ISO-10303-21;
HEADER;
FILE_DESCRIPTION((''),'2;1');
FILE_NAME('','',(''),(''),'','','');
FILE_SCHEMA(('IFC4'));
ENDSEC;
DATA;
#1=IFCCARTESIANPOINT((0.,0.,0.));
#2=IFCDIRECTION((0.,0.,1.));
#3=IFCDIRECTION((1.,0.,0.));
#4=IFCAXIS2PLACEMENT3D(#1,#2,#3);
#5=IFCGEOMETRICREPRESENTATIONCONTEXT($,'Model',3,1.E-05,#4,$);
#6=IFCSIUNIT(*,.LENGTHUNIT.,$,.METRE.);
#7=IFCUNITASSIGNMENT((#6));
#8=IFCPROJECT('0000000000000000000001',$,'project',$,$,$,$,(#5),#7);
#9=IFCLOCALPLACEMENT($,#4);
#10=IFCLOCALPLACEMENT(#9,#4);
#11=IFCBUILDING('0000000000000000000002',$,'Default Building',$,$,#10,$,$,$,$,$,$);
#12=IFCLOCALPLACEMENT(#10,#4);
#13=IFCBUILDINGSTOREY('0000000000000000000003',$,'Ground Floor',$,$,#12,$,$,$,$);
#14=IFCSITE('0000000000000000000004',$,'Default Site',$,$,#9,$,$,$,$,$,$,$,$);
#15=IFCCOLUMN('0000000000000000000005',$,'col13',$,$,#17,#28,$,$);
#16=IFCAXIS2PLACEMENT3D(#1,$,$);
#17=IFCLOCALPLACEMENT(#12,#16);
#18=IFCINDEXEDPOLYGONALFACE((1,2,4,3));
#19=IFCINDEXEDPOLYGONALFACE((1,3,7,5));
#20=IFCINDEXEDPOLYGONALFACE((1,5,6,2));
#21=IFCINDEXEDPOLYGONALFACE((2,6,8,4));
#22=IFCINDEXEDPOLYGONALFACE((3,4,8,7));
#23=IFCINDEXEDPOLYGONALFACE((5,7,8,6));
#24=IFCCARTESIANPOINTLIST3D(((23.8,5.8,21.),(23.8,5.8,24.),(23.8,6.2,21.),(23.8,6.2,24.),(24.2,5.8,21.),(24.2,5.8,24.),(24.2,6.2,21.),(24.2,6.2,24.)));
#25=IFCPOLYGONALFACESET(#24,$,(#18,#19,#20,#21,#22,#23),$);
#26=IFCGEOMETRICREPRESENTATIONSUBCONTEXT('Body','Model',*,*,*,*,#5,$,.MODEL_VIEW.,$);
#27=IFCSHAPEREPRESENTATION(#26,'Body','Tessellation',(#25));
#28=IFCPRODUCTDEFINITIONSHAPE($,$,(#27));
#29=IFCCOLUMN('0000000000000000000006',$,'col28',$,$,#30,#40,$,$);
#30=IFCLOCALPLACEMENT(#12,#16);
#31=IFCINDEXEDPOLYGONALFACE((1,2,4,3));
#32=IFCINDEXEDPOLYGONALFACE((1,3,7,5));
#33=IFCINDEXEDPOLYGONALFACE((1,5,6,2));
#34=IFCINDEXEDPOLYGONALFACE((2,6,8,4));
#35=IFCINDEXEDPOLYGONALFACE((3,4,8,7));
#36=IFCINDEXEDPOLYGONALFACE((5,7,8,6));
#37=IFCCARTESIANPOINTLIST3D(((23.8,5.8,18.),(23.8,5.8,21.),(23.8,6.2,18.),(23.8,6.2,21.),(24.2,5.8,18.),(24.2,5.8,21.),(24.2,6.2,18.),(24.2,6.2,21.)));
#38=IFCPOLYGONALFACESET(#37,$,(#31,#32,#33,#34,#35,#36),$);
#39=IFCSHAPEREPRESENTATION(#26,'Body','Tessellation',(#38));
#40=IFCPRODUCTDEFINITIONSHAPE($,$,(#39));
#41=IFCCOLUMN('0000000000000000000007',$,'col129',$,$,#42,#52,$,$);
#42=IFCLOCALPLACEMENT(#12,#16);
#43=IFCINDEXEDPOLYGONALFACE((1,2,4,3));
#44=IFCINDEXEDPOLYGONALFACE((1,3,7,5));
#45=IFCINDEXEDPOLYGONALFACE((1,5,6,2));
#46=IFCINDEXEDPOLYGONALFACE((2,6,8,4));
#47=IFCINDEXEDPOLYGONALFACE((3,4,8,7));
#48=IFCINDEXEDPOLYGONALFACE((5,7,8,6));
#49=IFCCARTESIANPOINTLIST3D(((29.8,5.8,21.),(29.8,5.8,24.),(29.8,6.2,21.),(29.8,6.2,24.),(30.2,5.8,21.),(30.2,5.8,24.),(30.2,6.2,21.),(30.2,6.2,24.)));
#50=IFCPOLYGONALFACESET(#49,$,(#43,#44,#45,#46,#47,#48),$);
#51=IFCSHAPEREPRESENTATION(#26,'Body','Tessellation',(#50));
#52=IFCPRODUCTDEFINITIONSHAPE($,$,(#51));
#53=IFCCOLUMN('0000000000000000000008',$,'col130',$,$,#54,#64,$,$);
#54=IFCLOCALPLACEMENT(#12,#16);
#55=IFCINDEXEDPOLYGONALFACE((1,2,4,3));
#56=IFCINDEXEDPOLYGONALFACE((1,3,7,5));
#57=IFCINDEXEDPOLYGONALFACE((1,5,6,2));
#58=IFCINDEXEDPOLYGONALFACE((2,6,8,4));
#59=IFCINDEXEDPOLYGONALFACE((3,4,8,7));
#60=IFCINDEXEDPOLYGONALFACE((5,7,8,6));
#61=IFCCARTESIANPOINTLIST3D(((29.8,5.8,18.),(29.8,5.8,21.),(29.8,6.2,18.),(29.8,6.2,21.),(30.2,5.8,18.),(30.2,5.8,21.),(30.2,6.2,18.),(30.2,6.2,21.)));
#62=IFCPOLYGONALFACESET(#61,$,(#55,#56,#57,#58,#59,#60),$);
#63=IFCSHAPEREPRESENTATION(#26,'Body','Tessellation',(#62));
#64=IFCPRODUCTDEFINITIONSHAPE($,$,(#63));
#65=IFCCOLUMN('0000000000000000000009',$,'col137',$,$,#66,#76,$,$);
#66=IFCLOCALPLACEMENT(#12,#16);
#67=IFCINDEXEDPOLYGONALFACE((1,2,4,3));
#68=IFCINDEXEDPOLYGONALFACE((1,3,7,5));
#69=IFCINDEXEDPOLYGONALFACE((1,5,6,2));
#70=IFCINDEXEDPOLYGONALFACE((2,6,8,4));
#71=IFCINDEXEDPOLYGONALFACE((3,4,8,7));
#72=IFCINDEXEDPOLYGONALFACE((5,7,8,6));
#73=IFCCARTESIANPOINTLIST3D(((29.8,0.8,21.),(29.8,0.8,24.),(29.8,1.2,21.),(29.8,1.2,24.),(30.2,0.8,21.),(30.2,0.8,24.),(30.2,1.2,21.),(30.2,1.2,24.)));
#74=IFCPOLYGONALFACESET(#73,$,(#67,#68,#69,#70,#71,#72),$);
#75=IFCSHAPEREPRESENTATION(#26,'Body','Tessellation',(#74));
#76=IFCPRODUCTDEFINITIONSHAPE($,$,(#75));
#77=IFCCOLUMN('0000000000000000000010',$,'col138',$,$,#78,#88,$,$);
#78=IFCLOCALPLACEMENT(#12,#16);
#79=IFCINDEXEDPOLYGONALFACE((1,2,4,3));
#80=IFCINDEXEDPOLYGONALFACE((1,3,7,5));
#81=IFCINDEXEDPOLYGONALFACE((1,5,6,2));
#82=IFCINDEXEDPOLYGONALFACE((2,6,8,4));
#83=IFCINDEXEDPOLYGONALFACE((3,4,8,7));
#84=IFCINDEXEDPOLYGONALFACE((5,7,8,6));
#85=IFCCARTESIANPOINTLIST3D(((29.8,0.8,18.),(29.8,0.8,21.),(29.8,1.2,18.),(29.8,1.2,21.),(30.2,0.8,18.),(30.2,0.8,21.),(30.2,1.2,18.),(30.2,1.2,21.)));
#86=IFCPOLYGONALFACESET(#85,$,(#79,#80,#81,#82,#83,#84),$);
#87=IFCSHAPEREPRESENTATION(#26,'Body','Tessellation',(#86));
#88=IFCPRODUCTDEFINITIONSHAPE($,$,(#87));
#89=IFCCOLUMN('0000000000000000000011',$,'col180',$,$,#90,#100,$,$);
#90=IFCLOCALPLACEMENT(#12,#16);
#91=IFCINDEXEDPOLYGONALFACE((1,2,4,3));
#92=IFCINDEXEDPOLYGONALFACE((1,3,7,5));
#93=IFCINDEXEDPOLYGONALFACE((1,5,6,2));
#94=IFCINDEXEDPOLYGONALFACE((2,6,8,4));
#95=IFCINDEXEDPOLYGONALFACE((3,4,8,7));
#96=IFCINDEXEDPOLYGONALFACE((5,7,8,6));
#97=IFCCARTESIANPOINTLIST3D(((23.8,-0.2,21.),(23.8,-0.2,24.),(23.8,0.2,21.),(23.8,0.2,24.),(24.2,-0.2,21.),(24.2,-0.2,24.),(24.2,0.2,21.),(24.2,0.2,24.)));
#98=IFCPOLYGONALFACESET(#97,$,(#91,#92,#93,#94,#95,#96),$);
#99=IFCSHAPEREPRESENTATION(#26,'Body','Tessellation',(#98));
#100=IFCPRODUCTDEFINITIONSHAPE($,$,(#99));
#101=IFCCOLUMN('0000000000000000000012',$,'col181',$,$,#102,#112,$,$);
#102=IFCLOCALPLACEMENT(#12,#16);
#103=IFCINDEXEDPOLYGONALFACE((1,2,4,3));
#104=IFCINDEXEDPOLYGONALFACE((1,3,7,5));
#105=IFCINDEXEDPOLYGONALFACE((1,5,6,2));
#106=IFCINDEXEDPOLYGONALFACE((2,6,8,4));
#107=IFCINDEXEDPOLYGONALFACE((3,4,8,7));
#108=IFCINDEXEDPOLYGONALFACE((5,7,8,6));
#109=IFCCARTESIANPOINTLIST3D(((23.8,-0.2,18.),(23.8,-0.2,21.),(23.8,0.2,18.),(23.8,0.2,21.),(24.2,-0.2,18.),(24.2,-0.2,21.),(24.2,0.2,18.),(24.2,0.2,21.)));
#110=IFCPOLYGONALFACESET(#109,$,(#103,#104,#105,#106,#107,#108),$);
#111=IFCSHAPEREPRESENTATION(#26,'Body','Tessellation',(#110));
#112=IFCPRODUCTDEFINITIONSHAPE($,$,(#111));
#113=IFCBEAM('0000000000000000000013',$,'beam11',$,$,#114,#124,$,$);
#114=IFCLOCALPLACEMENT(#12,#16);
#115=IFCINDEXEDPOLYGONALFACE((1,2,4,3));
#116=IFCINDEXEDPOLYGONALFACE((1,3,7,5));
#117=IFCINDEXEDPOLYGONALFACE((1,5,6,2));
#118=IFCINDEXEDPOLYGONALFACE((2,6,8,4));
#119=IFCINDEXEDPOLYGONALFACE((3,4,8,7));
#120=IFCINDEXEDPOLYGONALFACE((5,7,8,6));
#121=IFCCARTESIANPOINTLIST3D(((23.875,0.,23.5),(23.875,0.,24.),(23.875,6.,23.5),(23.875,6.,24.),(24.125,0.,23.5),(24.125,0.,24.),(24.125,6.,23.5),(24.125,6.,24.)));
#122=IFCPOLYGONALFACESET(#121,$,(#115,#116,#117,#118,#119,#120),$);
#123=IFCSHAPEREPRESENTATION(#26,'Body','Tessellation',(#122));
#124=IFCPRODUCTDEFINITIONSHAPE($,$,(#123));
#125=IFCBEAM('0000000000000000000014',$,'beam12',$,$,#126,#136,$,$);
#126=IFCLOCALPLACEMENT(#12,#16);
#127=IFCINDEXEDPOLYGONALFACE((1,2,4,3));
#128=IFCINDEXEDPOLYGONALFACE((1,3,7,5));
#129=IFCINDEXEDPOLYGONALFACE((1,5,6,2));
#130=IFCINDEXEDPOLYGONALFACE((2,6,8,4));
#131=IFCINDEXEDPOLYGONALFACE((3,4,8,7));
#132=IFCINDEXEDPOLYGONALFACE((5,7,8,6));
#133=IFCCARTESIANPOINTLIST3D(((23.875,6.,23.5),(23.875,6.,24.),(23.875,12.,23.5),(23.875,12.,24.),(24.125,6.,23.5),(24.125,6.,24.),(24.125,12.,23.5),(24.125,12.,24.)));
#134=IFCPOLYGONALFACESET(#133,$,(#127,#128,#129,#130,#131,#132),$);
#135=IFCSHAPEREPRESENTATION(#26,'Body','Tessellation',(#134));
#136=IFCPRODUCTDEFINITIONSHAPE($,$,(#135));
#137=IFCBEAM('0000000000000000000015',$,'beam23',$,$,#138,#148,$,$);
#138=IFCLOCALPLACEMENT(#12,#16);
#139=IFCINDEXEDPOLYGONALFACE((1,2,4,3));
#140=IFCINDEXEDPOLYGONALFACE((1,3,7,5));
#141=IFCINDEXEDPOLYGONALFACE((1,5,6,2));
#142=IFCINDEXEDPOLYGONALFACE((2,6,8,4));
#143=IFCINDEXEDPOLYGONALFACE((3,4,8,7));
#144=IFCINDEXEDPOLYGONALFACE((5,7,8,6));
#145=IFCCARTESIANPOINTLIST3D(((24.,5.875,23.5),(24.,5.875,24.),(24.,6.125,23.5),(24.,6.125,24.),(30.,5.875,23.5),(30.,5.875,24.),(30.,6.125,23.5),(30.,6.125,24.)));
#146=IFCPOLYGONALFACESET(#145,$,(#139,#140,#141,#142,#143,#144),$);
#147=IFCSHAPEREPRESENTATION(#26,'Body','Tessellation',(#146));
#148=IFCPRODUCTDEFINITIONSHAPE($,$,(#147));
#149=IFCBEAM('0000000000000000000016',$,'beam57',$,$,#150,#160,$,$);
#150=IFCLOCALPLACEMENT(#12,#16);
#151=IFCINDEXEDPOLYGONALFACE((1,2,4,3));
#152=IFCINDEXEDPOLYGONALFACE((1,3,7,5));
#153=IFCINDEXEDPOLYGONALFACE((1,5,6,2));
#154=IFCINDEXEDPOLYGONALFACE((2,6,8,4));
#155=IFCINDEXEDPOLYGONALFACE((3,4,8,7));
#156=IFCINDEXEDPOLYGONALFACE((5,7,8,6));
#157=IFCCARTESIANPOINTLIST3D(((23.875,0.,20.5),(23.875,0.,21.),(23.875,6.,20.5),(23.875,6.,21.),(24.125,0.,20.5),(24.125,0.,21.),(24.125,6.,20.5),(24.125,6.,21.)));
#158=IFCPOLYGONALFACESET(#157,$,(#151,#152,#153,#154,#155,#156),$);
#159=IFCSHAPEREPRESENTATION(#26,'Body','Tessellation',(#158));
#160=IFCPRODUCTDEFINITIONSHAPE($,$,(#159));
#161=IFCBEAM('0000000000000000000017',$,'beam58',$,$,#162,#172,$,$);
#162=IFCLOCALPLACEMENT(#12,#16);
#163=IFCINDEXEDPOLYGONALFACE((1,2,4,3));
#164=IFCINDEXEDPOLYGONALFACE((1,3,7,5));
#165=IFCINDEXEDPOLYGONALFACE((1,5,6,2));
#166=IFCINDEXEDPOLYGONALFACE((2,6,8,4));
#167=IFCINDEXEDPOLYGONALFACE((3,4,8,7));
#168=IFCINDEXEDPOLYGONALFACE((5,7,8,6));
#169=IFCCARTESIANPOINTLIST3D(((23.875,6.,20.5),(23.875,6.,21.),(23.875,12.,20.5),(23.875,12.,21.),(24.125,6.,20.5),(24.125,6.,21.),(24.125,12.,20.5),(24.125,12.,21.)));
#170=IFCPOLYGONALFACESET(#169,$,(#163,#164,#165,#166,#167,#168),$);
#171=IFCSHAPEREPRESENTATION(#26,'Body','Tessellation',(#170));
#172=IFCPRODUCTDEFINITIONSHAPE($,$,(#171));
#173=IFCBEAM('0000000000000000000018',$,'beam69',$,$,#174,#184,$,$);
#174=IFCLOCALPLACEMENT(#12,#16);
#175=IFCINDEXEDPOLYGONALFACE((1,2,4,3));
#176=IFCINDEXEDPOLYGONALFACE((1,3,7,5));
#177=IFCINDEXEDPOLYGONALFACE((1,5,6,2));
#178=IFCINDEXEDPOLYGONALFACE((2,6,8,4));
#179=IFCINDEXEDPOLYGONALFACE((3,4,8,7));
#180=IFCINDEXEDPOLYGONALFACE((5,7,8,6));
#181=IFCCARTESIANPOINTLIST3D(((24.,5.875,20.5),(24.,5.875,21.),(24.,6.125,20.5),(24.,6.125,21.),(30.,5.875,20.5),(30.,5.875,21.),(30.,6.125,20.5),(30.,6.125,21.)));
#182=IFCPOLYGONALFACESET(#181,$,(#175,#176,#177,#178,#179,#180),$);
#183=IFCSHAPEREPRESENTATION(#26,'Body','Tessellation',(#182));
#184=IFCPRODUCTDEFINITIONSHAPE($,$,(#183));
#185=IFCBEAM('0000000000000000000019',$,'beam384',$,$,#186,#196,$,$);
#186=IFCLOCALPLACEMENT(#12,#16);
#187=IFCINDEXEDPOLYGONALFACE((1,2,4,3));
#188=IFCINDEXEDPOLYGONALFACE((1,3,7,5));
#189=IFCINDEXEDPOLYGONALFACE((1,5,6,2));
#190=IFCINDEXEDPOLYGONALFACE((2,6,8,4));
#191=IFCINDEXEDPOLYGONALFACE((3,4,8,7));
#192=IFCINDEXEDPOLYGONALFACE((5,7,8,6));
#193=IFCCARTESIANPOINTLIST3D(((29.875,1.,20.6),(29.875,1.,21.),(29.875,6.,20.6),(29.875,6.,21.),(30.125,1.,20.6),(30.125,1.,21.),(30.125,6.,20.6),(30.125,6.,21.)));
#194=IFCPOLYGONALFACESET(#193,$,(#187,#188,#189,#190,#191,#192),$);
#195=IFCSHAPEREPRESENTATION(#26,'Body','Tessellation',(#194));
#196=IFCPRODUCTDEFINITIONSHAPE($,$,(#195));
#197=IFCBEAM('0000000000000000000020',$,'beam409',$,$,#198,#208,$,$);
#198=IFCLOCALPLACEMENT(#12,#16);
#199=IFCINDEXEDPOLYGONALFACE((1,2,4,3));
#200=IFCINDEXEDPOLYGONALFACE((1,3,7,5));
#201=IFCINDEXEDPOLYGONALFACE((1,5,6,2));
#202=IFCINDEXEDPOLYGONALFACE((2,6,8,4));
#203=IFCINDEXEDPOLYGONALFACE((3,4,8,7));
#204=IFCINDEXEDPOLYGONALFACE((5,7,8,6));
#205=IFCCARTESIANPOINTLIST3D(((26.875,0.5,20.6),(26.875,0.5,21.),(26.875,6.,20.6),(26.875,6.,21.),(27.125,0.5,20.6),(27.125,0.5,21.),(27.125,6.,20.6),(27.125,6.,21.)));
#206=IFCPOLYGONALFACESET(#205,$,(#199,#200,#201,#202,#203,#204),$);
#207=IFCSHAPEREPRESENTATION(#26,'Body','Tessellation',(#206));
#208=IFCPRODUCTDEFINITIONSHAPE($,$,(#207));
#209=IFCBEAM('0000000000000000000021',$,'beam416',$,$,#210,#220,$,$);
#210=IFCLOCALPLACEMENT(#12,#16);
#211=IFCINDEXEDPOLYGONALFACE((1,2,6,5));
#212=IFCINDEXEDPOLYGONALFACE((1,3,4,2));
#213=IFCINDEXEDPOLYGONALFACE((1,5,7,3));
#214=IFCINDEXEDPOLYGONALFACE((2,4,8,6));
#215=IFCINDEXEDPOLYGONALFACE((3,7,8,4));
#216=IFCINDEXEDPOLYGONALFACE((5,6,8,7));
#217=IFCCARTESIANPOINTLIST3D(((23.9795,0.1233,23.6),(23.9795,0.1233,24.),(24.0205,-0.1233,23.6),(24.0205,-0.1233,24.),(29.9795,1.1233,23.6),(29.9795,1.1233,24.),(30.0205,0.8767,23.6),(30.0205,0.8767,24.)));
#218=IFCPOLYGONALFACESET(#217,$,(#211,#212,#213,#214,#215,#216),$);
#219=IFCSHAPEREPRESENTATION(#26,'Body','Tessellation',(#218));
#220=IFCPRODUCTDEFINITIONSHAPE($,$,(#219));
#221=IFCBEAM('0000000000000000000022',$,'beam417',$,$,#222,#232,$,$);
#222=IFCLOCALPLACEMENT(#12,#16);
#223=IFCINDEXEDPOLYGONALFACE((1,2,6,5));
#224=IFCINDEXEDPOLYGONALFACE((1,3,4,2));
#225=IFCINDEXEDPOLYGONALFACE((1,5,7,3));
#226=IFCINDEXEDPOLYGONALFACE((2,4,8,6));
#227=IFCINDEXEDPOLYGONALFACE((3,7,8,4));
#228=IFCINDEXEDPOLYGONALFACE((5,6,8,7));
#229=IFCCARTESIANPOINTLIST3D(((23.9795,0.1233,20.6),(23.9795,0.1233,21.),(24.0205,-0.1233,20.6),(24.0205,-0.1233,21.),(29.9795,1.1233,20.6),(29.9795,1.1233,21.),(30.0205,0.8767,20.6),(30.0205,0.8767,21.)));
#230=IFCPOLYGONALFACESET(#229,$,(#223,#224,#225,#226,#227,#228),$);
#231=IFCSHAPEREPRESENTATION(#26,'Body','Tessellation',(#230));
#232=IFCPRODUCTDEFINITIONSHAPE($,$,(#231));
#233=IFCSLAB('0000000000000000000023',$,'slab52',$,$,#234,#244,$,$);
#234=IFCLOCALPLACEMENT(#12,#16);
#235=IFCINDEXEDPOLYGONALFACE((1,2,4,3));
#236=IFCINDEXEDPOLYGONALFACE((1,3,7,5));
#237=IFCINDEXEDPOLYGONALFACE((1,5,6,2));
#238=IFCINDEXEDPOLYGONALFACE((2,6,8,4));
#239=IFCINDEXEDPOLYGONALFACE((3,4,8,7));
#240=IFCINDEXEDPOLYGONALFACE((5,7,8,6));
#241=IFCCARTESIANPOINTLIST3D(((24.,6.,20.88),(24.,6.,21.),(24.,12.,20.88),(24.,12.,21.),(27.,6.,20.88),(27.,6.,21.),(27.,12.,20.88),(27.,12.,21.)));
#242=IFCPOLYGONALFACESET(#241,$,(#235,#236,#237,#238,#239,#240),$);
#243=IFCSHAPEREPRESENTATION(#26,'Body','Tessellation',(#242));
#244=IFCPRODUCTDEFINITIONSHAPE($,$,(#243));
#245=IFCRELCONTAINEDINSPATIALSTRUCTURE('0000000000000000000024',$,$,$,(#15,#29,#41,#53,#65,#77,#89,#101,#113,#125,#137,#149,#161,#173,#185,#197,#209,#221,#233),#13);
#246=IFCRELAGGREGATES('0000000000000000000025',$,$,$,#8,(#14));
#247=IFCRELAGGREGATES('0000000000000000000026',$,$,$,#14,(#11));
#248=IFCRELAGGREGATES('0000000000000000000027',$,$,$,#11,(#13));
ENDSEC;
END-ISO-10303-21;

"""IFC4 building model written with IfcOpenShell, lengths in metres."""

from ifc_helpers import new_model, si_unit, frame, origin_with_axes, place, context, subcontext, project, spatial, indexed_curve, outline, extrude, element, save


model = new_model("IFC4")

# Units and contexts
model_context = context("Model", 3, precision=1e-05, world=origin_with_axes())
body_context = subcontext(model_context, "Body", "Model", "MODEL_VIEW")
ifc_project = project(units=[si_unit("LENGTHUNIT", "METRE")], contexts=[model_context])

# Site, building, storey
site_placement = place(None, origin_with_axes())
site = spatial("IfcSite", under=ifc_project, at=site_placement, Name="Default Site")
building_placement = place(site_placement, origin_with_axes())
building = spatial("IfcBuilding", under=site, at=building_placement, Name="Default Building")
storey_placement = place(building_placement, origin_with_axes())
storey = spatial("IfcBuildingStorey", under=building, at=storey_placement, Name="Ground Floor")

# Columns
for number, where, z_axis, x_axis, name in (
    (1, (23.8, 5.8, 21.0), (0.0, 0.0, 1.0), (1.0, 0.0, 0.0), "col13"),
    (2, (23.8, 5.8, 18.0), (0.0, 0.0, 1.0), (1.0, 0.0, 0.0), "col28"),
    (3, (29.8, 5.8, 21.0), (0.0, 0.0, 1.0), (1.0, 0.0, 0.0), "col129"),
    (4, (29.8, 5.8, 18.0), (0.0, 0.0, 1.0), (1.0, 0.0, 0.0), "col130"),
    (5, (29.8, 0.8, 21.0), (0.0, 0.0, 1.0), (1.0, 0.0, 0.0), "col137"),
    (6, (29.8, 0.8, 18.0), (0.0, 0.0, 1.0), (1.0, 0.0, 0.0), "col138"),
    (7, (23.8, -0.2, 21.0), (0.0, 0.0, 1.0), (1.0, 0.0, 0.0), "col180"),
    (8, (23.8, -0.2, 18.0), (0.0, 0.0, 1.0), (1.0, 0.0, 0.0), "col181"),
):
    element("IfcColumn", number, at=place(storey_placement, frame(where, z_axis=z_axis, x_axis=x_axis)), inside=storey, Name=name, context=body_context, shape_type="SweptSolid", body=[
        extrude(outline(indexed_curve([(0.0, 0.0), (0.0, 0.4), (0.4, 0.4), (0.4, 0.0), (0.0, 0.0)], self_intersect=False)), origin_with_axes(), (0.0, 0.0, 1.0), 3.0),
    ])

# Beams
for number, where, z_axis, x_axis, name in (
    (9, (24.125, 0.0, 23.5), (0.0, 0.0, 1.0), (0.0, 1.0, 0.0), "beam11"),
    (10, (24.125, 6.0, 23.5), (0.0, 0.0, 1.0), (0.0, 1.0, 0.0), "beam12"),
    (11, (24.0, 5.875, 23.5), (0.0, 0.0, 1.0), (1.0, 0.0, 0.0), "beam23"),
    (12, (24.125, 0.0, 20.5), (0.0, 0.0, 1.0), (0.0, 1.0, 0.0), "beam57"),
    (13, (24.125, 6.0, 20.5), (0.0, 0.0, 1.0), (0.0, 1.0, 0.0), "beam58"),
    (14, (24.0, 5.875, 20.5), (0.0, 0.0, 1.0), (1.0, 0.0, 0.0), "beam69"),
):
    element("IfcBeam", number, at=place(storey_placement, frame(where, z_axis=z_axis, x_axis=x_axis)), inside=storey, Name=name, context=body_context, shape_type="SweptSolid", body=[
        extrude(outline(indexed_curve([(0.0, 0.0), (0.0, 0.25), (6.0, 0.25), (6.0, 0.0), (0.0, 0.0)], self_intersect=False)), origin_with_axes(), (0.0, 0.0, 1.0), 0.5),
    ])
beam_1_placement = place(storey_placement, frame((29.875, 6.0, 20.6), z_axis=(0.0, 0.0, 1.0), x_axis=(0.0, -1.0, 0.0)))
element("IfcBeam", 15, at=beam_1_placement, inside=storey, Name="beam384", context=body_context, shape_type="SweptSolid", body=[
    extrude(outline(indexed_curve([(0.0, 0.0), (0.0, 0.25), (5.0, 0.25), (5.0, 0.0), (0.0, 0.0)], self_intersect=False)), origin_with_axes(), (0.0, 0.0, 1.0), 0.4),
])
beam_2_placement = place(storey_placement, frame((26.875, 6.0, 20.6), z_axis=(0.0, 0.0, 1.0), x_axis=(0.0, -1.0, 0.0)))
element("IfcBeam", 16, at=beam_2_placement, inside=storey, Name="beam409", context=body_context, shape_type="SweptSolid", body=[
    extrude(outline(indexed_curve([(0.0, 0.0), (0.0, 0.25), (5.5, 0.25), (5.5, 0.0), (0.0, 0.0)], self_intersect=False)), origin_with_axes(), (0.0, 0.0, 1.0), 0.4),
])
for number, where, z_axis, x_axis, name in (
    (17, (24.0205, -0.1233, 23.6), (0.0, 0.0, 1.0), (0.986394, 0.164399, 0.0), "beam416"),
    (18, (24.0205, -0.1233, 20.6), (0.0, 0.0, 1.0), (0.986394, 0.164399, 0.0), "beam417"),
):
    element("IfcBeam", number, at=place(storey_placement, frame(where, z_axis=z_axis, x_axis=x_axis)), inside=storey, Name=name, context=body_context, shape_type="SweptSolid", body=[
        extrude(outline(indexed_curve([(0.0, 0.0), (0.0, 0.25), (6.0828, 0.25), (6.0828, 0.0), (0.0, 0.0)], self_intersect=False)), origin_with_axes(), (0.0, 0.0, 1.0), 0.4),
    ])

# Slab
for number, where, z_axis, x_axis, name in (
    (19, (24.0, 6.0, 20.88), (0.0, 0.0, 1.0), (1.0, 0.0, 0.0), "slab52"),
):
    element("IfcSlab", number, at=place(storey_placement, frame(where, z_axis=z_axis, x_axis=x_axis)), inside=storey, Name=name, context=body_context, shape_type="SweptSolid", body=[
        extrude(outline(indexed_curve([(0.0, 0.0), (0.0, 6.0), (3.0, 6.0), (3.0, 0.0), (0.0, 0.0)], self_intersect=False)), origin_with_axes(), (0.0, 0.0, 1.0), 0.12),
    ])

save(model, "model.ifc")
